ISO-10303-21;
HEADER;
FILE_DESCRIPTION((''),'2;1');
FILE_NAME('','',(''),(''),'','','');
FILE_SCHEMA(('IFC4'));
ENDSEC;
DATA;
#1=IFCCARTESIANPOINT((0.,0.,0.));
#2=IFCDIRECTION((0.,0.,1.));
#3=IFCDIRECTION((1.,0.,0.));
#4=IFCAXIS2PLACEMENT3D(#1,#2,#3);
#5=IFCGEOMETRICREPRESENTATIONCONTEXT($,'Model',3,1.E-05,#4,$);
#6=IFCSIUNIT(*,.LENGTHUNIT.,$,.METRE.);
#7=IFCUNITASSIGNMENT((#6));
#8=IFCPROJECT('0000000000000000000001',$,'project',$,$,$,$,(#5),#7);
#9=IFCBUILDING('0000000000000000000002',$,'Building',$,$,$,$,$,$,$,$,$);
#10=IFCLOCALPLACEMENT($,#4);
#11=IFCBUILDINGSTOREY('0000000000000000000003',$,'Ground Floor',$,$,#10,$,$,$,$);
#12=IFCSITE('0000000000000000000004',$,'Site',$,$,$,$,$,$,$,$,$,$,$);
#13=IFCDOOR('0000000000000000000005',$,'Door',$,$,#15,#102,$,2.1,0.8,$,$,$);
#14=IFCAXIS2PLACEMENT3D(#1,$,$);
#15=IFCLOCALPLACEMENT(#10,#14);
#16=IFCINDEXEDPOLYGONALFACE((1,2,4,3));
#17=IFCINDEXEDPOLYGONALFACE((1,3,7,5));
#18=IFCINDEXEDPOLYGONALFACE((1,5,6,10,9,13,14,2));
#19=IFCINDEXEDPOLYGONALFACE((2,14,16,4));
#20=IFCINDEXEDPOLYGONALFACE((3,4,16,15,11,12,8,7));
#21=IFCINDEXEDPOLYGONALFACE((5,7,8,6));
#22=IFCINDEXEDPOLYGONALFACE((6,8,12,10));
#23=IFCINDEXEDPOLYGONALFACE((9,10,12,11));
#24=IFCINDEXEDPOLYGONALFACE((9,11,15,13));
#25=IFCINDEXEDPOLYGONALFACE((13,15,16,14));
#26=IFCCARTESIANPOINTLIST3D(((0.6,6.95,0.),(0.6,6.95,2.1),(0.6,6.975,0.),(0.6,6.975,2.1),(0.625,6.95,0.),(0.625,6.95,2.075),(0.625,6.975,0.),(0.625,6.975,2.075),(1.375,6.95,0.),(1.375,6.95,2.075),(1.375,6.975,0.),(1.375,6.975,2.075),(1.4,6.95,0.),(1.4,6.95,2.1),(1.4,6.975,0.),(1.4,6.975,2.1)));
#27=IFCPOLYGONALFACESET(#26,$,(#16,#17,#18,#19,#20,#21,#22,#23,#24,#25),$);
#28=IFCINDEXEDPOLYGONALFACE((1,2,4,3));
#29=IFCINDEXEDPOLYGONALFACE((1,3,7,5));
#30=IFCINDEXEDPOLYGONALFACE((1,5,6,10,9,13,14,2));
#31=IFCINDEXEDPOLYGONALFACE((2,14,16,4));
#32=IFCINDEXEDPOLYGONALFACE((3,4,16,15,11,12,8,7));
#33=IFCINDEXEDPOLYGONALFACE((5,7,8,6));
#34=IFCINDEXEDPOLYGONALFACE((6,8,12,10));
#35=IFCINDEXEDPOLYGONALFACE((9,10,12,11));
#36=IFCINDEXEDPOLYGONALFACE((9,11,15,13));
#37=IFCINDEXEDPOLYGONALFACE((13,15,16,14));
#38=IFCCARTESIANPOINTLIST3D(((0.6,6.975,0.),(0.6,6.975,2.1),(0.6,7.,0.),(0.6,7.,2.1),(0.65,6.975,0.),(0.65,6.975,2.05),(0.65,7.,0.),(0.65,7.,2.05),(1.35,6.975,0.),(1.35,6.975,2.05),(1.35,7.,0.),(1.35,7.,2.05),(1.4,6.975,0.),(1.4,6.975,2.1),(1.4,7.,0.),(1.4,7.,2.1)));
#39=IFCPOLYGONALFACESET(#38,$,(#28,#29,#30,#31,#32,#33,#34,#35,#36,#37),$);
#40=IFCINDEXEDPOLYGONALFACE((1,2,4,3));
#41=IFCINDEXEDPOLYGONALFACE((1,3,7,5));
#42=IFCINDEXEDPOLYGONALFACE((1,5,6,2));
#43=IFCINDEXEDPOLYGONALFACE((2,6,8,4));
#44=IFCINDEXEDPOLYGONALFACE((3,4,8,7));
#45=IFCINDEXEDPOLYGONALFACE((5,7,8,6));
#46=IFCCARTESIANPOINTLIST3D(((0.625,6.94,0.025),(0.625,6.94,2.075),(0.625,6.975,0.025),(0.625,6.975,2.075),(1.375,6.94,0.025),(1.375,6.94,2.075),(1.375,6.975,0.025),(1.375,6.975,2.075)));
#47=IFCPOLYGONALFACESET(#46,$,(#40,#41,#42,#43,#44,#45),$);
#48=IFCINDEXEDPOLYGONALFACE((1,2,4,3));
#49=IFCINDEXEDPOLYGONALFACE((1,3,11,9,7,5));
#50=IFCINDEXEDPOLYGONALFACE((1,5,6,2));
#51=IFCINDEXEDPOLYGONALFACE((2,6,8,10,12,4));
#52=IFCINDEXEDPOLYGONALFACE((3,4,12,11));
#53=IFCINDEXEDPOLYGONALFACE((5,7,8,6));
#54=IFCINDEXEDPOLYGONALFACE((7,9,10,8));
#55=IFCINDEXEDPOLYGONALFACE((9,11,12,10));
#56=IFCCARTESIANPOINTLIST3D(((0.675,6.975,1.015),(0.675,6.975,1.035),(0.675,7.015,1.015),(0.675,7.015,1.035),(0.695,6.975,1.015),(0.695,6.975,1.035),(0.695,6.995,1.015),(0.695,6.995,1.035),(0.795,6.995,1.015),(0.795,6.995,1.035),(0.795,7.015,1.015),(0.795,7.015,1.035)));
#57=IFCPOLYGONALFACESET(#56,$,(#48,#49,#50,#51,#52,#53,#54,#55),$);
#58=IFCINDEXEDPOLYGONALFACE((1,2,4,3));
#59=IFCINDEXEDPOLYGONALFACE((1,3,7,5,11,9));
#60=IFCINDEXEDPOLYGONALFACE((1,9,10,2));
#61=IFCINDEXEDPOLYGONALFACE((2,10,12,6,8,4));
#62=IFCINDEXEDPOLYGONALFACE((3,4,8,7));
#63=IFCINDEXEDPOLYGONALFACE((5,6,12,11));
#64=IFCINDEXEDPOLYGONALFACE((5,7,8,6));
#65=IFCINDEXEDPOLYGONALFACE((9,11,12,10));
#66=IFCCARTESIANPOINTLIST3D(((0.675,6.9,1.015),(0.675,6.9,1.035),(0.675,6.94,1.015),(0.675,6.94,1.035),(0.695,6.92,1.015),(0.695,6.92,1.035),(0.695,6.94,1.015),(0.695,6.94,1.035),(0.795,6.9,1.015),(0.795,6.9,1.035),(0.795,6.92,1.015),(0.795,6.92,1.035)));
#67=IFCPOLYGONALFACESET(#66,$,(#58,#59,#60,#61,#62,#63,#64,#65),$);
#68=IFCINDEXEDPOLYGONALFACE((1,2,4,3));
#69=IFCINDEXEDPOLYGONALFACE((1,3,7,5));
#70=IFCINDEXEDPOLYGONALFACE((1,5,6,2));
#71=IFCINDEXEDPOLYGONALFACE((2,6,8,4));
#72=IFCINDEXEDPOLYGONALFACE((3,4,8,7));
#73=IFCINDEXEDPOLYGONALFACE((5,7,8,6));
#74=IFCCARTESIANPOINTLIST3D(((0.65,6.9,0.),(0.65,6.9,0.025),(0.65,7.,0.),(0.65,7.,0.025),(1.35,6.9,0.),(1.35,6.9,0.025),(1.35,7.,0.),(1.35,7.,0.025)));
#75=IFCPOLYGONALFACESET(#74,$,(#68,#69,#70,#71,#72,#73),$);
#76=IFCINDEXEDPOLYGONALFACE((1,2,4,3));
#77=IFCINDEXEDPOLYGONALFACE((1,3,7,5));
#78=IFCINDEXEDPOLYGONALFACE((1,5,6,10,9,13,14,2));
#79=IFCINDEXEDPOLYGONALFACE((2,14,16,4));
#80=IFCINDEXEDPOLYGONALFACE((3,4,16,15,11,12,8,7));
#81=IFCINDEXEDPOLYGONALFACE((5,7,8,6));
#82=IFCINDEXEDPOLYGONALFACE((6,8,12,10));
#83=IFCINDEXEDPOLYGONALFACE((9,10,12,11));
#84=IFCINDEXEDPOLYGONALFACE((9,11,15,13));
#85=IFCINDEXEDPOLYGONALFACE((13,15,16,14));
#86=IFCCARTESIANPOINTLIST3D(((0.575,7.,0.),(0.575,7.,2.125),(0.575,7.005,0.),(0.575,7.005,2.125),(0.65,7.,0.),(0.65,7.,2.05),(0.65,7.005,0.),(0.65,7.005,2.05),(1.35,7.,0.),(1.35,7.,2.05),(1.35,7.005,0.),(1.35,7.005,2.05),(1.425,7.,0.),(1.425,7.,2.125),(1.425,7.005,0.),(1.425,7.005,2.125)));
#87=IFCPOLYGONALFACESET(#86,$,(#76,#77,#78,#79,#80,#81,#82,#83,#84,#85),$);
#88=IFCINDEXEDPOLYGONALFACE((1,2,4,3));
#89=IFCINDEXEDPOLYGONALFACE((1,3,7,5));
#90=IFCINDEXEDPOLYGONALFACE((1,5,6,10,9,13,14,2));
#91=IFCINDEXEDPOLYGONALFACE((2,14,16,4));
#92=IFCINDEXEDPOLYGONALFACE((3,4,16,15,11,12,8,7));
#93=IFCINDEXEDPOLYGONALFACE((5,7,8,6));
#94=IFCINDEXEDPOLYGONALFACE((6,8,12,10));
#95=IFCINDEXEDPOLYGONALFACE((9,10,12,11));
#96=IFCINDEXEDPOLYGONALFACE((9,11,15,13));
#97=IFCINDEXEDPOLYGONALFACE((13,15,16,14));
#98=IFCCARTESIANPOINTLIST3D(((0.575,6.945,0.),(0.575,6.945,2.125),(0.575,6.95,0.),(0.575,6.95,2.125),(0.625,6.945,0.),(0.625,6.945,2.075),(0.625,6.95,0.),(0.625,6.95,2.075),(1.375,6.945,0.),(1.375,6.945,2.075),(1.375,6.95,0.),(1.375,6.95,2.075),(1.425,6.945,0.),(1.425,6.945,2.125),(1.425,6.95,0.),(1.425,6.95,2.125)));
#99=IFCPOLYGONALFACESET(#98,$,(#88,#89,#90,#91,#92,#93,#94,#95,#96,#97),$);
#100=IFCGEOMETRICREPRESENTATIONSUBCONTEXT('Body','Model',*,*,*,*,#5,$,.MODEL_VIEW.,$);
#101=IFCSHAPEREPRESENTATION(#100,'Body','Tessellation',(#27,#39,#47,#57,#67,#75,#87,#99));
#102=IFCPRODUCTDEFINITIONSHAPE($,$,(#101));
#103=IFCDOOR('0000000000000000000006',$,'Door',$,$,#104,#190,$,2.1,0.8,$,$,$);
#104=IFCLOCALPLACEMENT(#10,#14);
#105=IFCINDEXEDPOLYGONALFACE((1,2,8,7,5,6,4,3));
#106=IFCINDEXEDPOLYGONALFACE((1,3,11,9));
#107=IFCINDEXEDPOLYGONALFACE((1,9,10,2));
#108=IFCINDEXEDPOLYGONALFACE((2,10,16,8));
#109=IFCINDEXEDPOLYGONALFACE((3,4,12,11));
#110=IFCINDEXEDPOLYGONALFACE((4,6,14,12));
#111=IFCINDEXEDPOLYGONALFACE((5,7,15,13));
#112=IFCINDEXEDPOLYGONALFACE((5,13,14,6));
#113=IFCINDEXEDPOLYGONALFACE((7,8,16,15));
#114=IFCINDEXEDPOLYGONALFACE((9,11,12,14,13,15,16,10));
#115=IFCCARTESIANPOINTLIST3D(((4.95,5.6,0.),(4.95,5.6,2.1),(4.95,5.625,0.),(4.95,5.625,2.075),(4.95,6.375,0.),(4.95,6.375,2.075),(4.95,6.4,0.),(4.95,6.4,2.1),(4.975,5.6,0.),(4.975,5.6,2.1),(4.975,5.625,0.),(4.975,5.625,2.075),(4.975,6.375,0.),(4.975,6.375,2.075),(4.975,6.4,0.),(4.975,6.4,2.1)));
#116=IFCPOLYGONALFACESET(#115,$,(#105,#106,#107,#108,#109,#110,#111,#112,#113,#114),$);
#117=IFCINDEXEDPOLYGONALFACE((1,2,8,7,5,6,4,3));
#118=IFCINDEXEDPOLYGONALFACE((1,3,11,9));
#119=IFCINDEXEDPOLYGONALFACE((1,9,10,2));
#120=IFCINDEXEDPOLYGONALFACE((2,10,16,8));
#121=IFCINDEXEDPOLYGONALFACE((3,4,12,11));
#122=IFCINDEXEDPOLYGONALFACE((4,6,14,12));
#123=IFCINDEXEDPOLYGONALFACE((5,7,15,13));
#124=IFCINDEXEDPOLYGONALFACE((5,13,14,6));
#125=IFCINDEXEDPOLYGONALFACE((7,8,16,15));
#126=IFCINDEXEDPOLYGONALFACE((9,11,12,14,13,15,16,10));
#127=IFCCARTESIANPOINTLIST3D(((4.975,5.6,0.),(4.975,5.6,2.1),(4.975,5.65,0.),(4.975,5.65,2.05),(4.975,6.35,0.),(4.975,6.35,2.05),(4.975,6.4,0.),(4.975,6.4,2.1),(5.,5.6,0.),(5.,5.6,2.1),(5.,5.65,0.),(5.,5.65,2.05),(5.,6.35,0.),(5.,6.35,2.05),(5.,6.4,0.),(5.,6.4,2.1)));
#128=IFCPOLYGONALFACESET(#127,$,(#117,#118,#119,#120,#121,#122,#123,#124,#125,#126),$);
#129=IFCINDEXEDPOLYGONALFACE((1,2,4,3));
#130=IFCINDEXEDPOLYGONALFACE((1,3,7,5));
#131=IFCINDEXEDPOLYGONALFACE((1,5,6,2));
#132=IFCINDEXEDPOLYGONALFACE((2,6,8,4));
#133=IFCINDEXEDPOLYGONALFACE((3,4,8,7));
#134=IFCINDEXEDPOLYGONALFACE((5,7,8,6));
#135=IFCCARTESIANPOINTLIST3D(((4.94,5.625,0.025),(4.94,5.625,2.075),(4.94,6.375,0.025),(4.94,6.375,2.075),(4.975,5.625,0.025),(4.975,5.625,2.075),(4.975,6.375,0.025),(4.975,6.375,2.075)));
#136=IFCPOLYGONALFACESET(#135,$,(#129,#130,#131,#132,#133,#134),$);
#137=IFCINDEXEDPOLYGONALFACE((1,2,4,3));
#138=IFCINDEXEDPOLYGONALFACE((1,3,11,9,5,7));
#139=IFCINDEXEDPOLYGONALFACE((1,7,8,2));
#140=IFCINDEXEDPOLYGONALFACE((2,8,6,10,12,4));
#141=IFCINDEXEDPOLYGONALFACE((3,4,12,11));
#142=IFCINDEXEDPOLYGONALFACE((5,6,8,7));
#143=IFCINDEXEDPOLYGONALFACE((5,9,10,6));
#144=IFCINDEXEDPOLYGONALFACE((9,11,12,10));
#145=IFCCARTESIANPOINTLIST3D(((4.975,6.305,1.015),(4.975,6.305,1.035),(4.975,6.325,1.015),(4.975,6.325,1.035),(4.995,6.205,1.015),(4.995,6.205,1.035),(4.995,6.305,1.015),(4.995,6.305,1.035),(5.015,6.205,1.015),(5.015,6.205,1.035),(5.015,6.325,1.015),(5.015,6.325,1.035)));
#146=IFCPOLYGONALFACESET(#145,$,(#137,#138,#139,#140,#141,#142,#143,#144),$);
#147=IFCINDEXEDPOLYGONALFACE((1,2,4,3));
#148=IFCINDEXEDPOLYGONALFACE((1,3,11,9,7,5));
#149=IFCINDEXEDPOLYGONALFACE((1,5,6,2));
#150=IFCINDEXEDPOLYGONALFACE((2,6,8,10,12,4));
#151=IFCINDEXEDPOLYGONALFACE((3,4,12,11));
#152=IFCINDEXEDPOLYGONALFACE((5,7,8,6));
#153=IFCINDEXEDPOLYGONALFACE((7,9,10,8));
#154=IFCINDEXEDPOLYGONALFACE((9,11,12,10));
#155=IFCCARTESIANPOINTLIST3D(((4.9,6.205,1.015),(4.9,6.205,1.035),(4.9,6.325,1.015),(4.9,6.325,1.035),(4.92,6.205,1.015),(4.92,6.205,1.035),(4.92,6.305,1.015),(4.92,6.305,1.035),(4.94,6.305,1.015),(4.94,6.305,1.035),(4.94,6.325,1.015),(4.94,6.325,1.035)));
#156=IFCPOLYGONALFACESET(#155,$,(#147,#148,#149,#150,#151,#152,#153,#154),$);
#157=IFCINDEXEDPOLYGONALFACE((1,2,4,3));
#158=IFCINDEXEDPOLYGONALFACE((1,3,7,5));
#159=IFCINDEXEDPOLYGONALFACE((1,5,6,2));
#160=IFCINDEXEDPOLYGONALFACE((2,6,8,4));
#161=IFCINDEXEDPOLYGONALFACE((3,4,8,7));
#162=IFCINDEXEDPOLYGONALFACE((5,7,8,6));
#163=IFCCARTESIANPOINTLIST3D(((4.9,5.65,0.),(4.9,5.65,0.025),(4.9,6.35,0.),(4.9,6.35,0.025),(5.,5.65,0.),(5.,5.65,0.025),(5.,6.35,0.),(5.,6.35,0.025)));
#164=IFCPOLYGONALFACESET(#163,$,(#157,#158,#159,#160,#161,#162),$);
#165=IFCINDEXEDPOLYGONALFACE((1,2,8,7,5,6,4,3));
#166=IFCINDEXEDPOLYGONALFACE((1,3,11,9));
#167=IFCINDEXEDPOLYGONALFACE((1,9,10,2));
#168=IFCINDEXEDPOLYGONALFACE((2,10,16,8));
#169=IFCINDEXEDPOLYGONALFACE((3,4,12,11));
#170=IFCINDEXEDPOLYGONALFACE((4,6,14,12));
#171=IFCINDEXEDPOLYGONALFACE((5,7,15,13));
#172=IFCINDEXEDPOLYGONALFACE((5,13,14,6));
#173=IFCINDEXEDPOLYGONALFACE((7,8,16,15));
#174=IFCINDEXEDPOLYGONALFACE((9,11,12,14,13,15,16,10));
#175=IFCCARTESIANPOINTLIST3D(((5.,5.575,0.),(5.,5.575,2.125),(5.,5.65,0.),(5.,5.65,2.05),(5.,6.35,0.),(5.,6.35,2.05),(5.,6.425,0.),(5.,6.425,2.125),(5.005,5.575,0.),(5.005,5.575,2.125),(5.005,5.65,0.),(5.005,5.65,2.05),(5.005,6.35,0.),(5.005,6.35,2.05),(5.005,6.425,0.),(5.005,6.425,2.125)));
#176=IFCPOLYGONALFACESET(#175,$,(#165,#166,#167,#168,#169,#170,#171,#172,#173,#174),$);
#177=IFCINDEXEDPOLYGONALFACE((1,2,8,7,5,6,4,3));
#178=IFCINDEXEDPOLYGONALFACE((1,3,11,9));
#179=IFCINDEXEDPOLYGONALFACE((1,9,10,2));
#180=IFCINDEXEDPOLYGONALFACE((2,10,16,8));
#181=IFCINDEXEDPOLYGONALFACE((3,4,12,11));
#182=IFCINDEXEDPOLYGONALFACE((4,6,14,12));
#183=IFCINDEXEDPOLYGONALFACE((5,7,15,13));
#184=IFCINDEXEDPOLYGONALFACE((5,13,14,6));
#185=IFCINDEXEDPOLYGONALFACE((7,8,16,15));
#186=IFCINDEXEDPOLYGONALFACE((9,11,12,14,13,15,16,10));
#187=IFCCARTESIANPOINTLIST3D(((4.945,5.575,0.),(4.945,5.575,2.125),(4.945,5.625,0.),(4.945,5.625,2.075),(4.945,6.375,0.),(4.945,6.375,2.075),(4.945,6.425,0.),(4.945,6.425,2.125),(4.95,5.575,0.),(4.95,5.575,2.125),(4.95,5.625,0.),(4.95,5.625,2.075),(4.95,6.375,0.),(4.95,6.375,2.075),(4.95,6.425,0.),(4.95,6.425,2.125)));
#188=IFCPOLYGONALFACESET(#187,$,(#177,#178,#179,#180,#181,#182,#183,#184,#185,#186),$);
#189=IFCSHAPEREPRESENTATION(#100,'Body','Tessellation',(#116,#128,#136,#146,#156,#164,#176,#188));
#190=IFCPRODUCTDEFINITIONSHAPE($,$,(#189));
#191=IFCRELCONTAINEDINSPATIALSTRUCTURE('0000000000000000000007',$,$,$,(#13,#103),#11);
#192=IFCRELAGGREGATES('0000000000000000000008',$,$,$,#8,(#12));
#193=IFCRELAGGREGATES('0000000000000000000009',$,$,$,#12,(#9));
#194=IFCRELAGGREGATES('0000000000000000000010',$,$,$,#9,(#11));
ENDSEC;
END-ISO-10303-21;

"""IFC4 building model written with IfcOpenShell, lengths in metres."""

from ifc_helpers import new_model, si_unit, frame, origin_with_axes, place, context, subcontext, project, spatial, line, indexed_curve, outline, extrude, element, save


model = new_model("IFC4")

# Units and contexts
model_context = context("Model", 3, precision=1e-05, world=origin_with_axes())
body_context = subcontext(model_context, "Body", "Model", "MODEL_VIEW")
ifc_project = project(units=[si_unit("LENGTHUNIT", "METRE")], contexts=[model_context])

# Site, building, storey
site = spatial("IfcSite", under=ifc_project, Name="Site")
building = spatial("IfcBuilding", under=site, Name="Building")
storey_placement = place(None, origin_with_axes())
storey = spatial("IfcBuildingStorey", under=building, at=storey_placement, Name="Ground Floor")

# Doors
door_1_placement = place(storey_placement, frame((1.4, 7.0, 0.0), z_axis=(0.0, 0.0, 1.0), x_axis=(-1.0, 0.0, 0.0)))
element("IfcDoor", 1, at=door_1_placement, inside=storey, Name="Door", OverallHeight=2.1, OverallWidth=0.8, context=body_context, shape_type="SweptSolid", body=[
    extrude(outline(indexed_curve([(0.0, 0.0), (0.0, 2.1), (0.8, 2.1), (0.8, 0.0), (0.775, 0.0), (0.775, 2.075), (0.025, 2.075), (0.025, 0.0)], segments=[line(1, 2, 3, 4, 5, 6, 7, 8, 1)])), frame((0.0, 0.025, 0.0), z_axis=(0.0, -1.0, 0.0), x_axis=(1.0, 0.0, 0.0)), (0.0, 0.0, -1.0), 0.025),
    extrude(outline(indexed_curve([(0.0, 0.0), (0.0, 2.1), (0.8, 2.1), (0.8, 0.0), (0.75, 0.0), (0.75, 2.05), (0.05, 2.05), (0.05, 0.0)], segments=[line(1, 2, 3, 4, 5, 6, 7, 8, 1)])), frame((0.0, 0.0, 0.0), z_axis=(0.0, -1.0, 0.0), x_axis=(1.0, 0.0, 0.0)), (0.0, 0.0, -1.0), 0.025),
    extrude(outline(indexed_curve([(0.0, 0.0), (0.75, 0.0), (0.75, 0.035), (0.0, 0.035)], segments=[line(1, 2, 3, 4, 1)])), frame((0.025, 0.025, 0.025), z_axis=(0.0, 0.0, 1.0), x_axis=(1.0, 0.0, 0.0)), (0.0, 0.0, 1.0), 2.05),
    extrude(outline(indexed_curve([(0.0, 0.0), (0.0, -0.04), (-0.12, -0.04), (-0.12, -0.02), (-0.02, -0.02), (-0.02, 0.0)], segments=[line(1, 2, 3, 4, 5, 6, 1)])), frame((0.725, 0.025, 1.015), z_axis=(0.0, 0.0, 1.0), x_axis=(1.0, 0.0, 0.0)), (0.0, 0.0, 1.0), 0.02),
    extrude(outline(indexed_curve([(0.0, 0.0), (0.0, 0.04), (-0.12, 0.04), (-0.12, 0.02), (-0.02, 0.02), (-0.02, 0.0)], segments=[line(1, 2, 3, 4, 5, 6, 1)])), frame((0.725, 0.06, 1.015), z_axis=(0.0, 0.0, 1.0), x_axis=(1.0, 0.0, 0.0)), (0.0, 0.0, 1.0), 0.02),
    extrude(outline(indexed_curve([(0.0, 0.0), (0.7, 0.0), (0.7, 0.1), (0.0, 0.1)], segments=[line(1, 2, 3, 4, 1)])), frame((0.05, 0.0, 0.0), z_axis=(0.0, 0.0, 1.0), x_axis=(1.0, 0.0, 0.0)), (0.0, 0.0, 1.0), 0.025),
    extrude(outline(indexed_curve([(0.0, 0.0), (0.0, 2.125), (0.85, 2.125), (0.85, 0.0), (0.775, 0.0), (0.775, 2.05), (0.075, 2.05), (0.075, 0.0)], segments=[line(1, 2, 3, 4, 5, 6, 7, 8, 1)])), frame((-0.025, -0.005, 0.0), z_axis=(0.0, -1.0, 0.0), x_axis=(1.0, 0.0, 0.0)), (0.0, 0.0, -1.0), 0.005),
    extrude(outline(indexed_curve([(0.0, 0.0), (0.0, 2.125), (0.85, 2.125), (0.85, 0.0), (0.8, 0.0), (0.8, 2.075), (0.05, 2.075), (0.05, 0.0)], segments=[line(1, 2, 3, 4, 5, 6, 7, 8, 1)])), frame((-0.025, 0.05, 0.0), z_axis=(0.0, -1.0, 0.0), x_axis=(1.0, 0.0, 0.0)), (0.0, 0.0, -1.0), 0.005),
])
door_2_placement = place(storey_placement, frame((5.0, 5.6, 0.0), z_axis=(0.0, 0.0, 1.0), x_axis=(0.0, 1.0, 0.0)))
element("IfcDoor", 2, at=door_2_placement, inside=storey, Name="Door", OverallHeight=2.1, OverallWidth=0.8, context=body_context, shape_type="SweptSolid", body=[
    extrude(outline(indexed_curve([(0.0, 0.0), (0.0, 2.1), (0.8, 2.1), (0.8, 0.0), (0.775, 0.0), (0.775, 2.075), (0.025, 2.075), (0.025, 0.0)], segments=[line(1, 2, 3, 4, 5, 6, 7, 8, 1)])), frame((0.0, 0.025, 0.0), z_axis=(0.0, -1.0, 0.0), x_axis=(1.0, 0.0, 0.0)), (0.0, 0.0, -1.0), 0.025),
    extrude(outline(indexed_curve([(0.0, 0.0), (0.0, 2.1), (0.8, 2.1), (0.8, 0.0), (0.75, 0.0), (0.75, 2.05), (0.05, 2.05), (0.05, 0.0)], segments=[line(1, 2, 3, 4, 5, 6, 7, 8, 1)])), frame((0.0, 0.0, 0.0), z_axis=(0.0, -1.0, 0.0), x_axis=(1.0, 0.0, 0.0)), (0.0, 0.0, -1.0), 0.025),
    extrude(outline(indexed_curve([(0.0, 0.0), (0.75, 0.0), (0.75, 0.035), (0.0, 0.035)], segments=[line(1, 2, 3, 4, 1)])), frame((0.025, 0.025, 0.025), z_axis=(0.0, 0.0, 1.0), x_axis=(1.0, 0.0, 0.0)), (0.0, 0.0, 1.0), 2.05),
    extrude(outline(indexed_curve([(0.0, 0.0), (0.0, -0.04), (-0.12, -0.04), (-0.12, -0.02), (-0.02, -0.02), (-0.02, 0.0)], segments=[line(1, 2, 3, 4, 5, 6, 1)])), frame((0.725, 0.025, 1.015), z_axis=(0.0, 0.0, 1.0), x_axis=(1.0, 0.0, 0.0)), (0.0, 0.0, 1.0), 0.02),
    extrude(outline(indexed_curve([(0.0, 0.0), (0.0, 0.04), (-0.12, 0.04), (-0.12, 0.02), (-0.02, 0.02), (-0.02, 0.0)], segments=[line(1, 2, 3, 4, 5, 6, 1)])), frame((0.725, 0.06, 1.015), z_axis=(0.0, 0.0, 1.0), x_axis=(1.0, 0.0, 0.0)), (0.0, 0.0, 1.0), 0.02),
    extrude(outline(indexed_curve([(0.0, 0.0), (0.7, 0.0), (0.7, 0.1), (0.0, 0.1)], segments=[line(1, 2, 3, 4, 1)])), frame((0.05, 0.0, 0.0), z_axis=(0.0, 0.0, 1.0), x_axis=(1.0, 0.0, 0.0)), (0.0, 0.0, 1.0), 0.025),
    extrude(outline(indexed_curve([(0.0, 0.0), (0.0, 2.125), (0.85, 2.125), (0.85, 0.0), (0.775, 0.0), (0.775, 2.05), (0.075, 2.05), (0.075, 0.0)], segments=[line(1, 2, 3, 4, 5, 6, 7, 8, 1)])), frame((-0.025, -0.005, 0.0), z_axis=(0.0, -1.0, 0.0), x_axis=(1.0, 0.0, 0.0)), (0.0, 0.0, -1.0), 0.005),
    extrude(outline(indexed_curve([(0.0, 0.0), (0.0, 2.125), (0.85, 2.125), (0.85, 0.0), (0.8, 0.0), (0.8, 2.075), (0.05, 2.075), (0.05, 0.0)], segments=[line(1, 2, 3, 4, 5, 6, 7, 8, 1)])), frame((-0.025, 0.05, 0.0), z_axis=(0.0, -1.0, 0.0), x_axis=(1.0, 0.0, 0.0)), (0.0, 0.0, -1.0), 0.005),
])

save(model, "model.ifc")
